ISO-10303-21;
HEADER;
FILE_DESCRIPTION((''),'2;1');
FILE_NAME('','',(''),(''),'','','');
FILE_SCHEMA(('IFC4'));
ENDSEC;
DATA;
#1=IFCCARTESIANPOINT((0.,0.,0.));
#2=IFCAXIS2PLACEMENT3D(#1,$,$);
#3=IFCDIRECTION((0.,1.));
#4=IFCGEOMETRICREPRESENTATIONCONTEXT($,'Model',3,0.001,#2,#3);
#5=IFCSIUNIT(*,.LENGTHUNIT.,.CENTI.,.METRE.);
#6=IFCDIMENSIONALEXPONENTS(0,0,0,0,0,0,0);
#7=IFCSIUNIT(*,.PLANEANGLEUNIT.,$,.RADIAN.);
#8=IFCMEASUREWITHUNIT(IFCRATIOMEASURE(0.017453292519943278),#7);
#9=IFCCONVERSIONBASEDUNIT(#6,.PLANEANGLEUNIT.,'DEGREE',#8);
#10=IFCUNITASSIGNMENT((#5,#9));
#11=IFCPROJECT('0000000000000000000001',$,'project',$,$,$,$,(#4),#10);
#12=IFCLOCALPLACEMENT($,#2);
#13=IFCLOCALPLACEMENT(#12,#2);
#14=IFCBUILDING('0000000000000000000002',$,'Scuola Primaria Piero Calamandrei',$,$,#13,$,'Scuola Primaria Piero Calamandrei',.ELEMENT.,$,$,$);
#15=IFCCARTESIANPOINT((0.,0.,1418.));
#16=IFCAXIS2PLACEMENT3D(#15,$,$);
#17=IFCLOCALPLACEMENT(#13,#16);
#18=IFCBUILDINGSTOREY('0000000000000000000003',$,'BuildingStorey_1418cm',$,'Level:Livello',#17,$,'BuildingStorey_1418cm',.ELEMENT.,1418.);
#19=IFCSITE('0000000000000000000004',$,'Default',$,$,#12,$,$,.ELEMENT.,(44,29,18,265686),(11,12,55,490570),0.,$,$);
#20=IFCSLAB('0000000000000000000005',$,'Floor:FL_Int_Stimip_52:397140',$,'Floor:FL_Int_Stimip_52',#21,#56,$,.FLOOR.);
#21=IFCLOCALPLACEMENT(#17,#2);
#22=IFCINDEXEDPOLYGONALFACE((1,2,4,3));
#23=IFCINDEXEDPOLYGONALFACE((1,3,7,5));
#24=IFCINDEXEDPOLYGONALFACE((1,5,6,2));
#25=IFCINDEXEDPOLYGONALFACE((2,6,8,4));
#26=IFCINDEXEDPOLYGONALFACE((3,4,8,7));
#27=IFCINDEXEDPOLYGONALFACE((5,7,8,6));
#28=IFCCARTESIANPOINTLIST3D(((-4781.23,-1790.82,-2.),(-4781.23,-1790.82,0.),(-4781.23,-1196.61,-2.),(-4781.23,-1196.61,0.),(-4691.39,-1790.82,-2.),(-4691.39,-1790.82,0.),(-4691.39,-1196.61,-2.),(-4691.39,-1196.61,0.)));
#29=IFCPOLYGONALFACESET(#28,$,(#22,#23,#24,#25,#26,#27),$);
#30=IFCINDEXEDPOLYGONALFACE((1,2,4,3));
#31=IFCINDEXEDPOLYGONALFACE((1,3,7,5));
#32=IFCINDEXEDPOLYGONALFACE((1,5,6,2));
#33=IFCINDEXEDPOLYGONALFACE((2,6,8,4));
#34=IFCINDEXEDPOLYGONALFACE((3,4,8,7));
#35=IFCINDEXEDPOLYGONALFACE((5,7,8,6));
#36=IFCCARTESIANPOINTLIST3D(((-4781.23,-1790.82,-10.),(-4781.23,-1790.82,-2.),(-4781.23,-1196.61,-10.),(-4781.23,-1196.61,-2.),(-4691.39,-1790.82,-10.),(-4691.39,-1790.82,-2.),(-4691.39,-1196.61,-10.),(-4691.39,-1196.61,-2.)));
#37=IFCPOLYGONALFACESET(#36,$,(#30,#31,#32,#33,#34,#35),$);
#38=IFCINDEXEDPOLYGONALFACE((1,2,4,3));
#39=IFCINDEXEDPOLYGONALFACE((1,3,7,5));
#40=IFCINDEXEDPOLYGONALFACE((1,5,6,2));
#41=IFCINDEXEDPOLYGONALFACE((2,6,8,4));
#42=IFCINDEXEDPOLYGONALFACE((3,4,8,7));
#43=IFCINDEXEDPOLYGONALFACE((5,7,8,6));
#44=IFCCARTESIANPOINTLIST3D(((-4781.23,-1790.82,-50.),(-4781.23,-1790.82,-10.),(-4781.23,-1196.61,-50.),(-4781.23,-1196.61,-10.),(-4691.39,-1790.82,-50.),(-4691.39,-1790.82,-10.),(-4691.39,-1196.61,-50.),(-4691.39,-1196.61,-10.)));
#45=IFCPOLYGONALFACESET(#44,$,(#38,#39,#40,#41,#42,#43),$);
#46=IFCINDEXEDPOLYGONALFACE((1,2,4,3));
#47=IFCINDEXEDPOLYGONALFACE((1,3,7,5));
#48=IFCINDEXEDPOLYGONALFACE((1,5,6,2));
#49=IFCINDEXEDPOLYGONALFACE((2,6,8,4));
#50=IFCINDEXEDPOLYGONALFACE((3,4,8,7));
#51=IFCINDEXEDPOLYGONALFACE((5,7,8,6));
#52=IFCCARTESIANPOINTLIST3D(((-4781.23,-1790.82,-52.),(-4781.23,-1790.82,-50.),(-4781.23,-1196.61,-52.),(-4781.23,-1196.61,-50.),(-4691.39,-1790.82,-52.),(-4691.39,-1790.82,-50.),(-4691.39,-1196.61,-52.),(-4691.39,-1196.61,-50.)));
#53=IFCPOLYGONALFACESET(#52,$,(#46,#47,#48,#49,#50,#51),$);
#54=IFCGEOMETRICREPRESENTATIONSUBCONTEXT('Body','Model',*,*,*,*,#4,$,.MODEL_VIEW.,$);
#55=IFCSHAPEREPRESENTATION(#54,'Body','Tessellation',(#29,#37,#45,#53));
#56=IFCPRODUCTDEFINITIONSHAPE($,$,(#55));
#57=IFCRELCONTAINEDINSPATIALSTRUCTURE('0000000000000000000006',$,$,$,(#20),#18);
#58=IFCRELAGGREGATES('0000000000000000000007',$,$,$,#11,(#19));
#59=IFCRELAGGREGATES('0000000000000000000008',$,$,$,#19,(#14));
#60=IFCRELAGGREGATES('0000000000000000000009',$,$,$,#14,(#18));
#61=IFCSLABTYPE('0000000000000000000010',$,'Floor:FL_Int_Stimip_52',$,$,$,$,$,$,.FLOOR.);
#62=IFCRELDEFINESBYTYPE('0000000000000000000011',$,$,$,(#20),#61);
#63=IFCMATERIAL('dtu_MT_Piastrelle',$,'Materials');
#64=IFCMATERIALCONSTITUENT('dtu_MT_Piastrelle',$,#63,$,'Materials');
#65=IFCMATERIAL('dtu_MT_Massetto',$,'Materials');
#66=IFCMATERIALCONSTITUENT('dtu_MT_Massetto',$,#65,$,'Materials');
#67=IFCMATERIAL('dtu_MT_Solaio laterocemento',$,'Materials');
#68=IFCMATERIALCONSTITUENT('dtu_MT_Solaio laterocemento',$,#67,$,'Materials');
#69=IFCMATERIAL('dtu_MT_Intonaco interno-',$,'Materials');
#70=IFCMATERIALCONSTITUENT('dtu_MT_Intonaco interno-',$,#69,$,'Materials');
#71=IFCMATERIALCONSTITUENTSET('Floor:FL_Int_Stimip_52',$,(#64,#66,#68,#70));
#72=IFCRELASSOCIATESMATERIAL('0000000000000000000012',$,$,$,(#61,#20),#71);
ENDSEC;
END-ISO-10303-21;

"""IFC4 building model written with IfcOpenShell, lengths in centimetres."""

from ifc_helpers import new_model, entity, si_unit, converted_unit, direction, frame, origin, place, context, subcontext, project, spatial, indexed_curve, outline, extrude, material, constituent, constituent_set, type_object, element, save


model = new_model("IFC4")

# Units and contexts
model_context = context("Model", 3, precision=0.001, world=origin(), true_north=direction((0.0, 1.0)))
body_context = subcontext(model_context, "Body", "Model", "MODEL_VIEW")
ifc_project = project(units=[si_unit("LENGTHUNIT", "METRE", prefix="CENTI"), converted_unit("PLANEANGLEUNIT", "DEGREE", entity("IfcRatioMeasure", 0.017453292519943278), si_unit("PLANEANGLEUNIT", "RADIAN"), dimensions=[0, 0, 0, 0, 0, 0, 0])], contexts=[model_context])

# Site, building, storey
site_placement = place(None, origin())
site = spatial("IfcSite", under=ifc_project, at=site_placement, Name="Default", CompositionType="ELEMENT", RefLatitude=(44, 29, 18, 265686), RefLongitude=(11, 12, 55, 490570), RefElevation=0.0)
building_placement = place(site_placement, origin())
building = spatial("IfcBuilding", under=site, at=building_placement, Name="Scuola Primaria Piero Calamandrei", LongName="Scuola Primaria Piero Calamandrei", CompositionType="ELEMENT")
storey_placement = place(building_placement, frame((0.0, 0.0, 1418.0)))
storey = spatial("IfcBuildingStorey", under=building, at=storey_placement, Name="BuildingStorey_1418cm", ObjectType="Level:Livello", LongName="BuildingStorey_1418cm", CompositionType="ELEMENT", Elevation=1418.0)

# Slab
ifc_material_1 = material(Name="dtu_MT_Piastrelle", Category="Materials")
ifc_constituent_1 = constituent(ifc_material_1, Name="dtu_MT_Piastrelle", Category="Materials")
ifc_material_2 = material(Name="dtu_MT_Massetto", Category="Materials")
ifc_constituent_2 = constituent(ifc_material_2, Name="dtu_MT_Massetto", Category="Materials")
ifc_material_3 = material(Name="dtu_MT_Solaio laterocemento", Category="Materials")
ifc_constituent_3 = constituent(ifc_material_3, Name="dtu_MT_Solaio laterocemento", Category="Materials")
ifc_material_4 = material(Name="dtu_MT_Intonaco interno-", Category="Materials")
ifc_constituent_4 = constituent(ifc_material_4, Name="dtu_MT_Intonaco interno-", Category="Materials")
ifc_constituent_set = constituent_set(constituents=[ifc_constituent_1, ifc_constituent_2, ifc_constituent_3, ifc_constituent_4], Name="Floor:FL_Int_Stimip_52")
slab_type_1 = type_object("IfcSlabType", Name="Floor:FL_Int_Stimip_52", PredefinedType="FLOOR", material=ifc_constituent_set)
slab_1_placement = place(storey_placement, origin())
element("IfcSlab", 1, at=slab_1_placement, inside=storey, type_object=slab_type_1, material=ifc_constituent_set, Name="Floor:FL_Int_Stimip_52:397140", ObjectType="Floor:FL_Int_Stimip_52", PredefinedType="FLOOR", context=body_context, shape_type="SweptSolid", body=[
    extrude(outline(indexed_curve([(-297.11, -44.92), (297.11, -44.92), (297.11, 44.92), (-297.11, 44.92), (-297.11, -44.92)], self_intersect=False)), frame((-4736.31, -1493.71, -2.0), z_axis=(0.0, 0.0, 1.0), x_axis=(0.0, 1.0, 0.0)), (0.0, 0.0, 1.0), 2.0),
    extrude(outline(indexed_curve([(-297.11, -44.92), (297.11, -44.92), (297.11, 44.92), (-297.11, 44.92), (-297.11, -44.92)], self_intersect=False)), frame((-4736.31, -1493.71, -10.0), z_axis=(0.0, 0.0, 1.0), x_axis=(0.0, 1.0, 0.0)), (0.0, 0.0, 1.0), 8.0),
    extrude(outline(indexed_curve([(-297.11, -44.92), (297.11, -44.92), (297.11, 44.92), (-297.11, 44.92), (-297.11, -44.92)], self_intersect=False)), frame((-4736.31, -1493.71, -50.0), z_axis=(0.0, 0.0, 1.0), x_axis=(0.0, 1.0, 0.0)), (0.0, 0.0, 1.0), 40.0),
    extrude(outline(indexed_curve([(-297.11, -44.92), (297.11, -44.92), (297.11, 44.92), (-297.11, 44.92), (-297.11, -44.92)], self_intersect=False)), frame((-4736.31, -1493.71, -52.0), z_axis=(0.0, 0.0, 1.0), x_axis=(0.0, 1.0, 0.0)), (0.0, 0.0, 1.0), 2.0),
])

save(model, "model.ifc")
